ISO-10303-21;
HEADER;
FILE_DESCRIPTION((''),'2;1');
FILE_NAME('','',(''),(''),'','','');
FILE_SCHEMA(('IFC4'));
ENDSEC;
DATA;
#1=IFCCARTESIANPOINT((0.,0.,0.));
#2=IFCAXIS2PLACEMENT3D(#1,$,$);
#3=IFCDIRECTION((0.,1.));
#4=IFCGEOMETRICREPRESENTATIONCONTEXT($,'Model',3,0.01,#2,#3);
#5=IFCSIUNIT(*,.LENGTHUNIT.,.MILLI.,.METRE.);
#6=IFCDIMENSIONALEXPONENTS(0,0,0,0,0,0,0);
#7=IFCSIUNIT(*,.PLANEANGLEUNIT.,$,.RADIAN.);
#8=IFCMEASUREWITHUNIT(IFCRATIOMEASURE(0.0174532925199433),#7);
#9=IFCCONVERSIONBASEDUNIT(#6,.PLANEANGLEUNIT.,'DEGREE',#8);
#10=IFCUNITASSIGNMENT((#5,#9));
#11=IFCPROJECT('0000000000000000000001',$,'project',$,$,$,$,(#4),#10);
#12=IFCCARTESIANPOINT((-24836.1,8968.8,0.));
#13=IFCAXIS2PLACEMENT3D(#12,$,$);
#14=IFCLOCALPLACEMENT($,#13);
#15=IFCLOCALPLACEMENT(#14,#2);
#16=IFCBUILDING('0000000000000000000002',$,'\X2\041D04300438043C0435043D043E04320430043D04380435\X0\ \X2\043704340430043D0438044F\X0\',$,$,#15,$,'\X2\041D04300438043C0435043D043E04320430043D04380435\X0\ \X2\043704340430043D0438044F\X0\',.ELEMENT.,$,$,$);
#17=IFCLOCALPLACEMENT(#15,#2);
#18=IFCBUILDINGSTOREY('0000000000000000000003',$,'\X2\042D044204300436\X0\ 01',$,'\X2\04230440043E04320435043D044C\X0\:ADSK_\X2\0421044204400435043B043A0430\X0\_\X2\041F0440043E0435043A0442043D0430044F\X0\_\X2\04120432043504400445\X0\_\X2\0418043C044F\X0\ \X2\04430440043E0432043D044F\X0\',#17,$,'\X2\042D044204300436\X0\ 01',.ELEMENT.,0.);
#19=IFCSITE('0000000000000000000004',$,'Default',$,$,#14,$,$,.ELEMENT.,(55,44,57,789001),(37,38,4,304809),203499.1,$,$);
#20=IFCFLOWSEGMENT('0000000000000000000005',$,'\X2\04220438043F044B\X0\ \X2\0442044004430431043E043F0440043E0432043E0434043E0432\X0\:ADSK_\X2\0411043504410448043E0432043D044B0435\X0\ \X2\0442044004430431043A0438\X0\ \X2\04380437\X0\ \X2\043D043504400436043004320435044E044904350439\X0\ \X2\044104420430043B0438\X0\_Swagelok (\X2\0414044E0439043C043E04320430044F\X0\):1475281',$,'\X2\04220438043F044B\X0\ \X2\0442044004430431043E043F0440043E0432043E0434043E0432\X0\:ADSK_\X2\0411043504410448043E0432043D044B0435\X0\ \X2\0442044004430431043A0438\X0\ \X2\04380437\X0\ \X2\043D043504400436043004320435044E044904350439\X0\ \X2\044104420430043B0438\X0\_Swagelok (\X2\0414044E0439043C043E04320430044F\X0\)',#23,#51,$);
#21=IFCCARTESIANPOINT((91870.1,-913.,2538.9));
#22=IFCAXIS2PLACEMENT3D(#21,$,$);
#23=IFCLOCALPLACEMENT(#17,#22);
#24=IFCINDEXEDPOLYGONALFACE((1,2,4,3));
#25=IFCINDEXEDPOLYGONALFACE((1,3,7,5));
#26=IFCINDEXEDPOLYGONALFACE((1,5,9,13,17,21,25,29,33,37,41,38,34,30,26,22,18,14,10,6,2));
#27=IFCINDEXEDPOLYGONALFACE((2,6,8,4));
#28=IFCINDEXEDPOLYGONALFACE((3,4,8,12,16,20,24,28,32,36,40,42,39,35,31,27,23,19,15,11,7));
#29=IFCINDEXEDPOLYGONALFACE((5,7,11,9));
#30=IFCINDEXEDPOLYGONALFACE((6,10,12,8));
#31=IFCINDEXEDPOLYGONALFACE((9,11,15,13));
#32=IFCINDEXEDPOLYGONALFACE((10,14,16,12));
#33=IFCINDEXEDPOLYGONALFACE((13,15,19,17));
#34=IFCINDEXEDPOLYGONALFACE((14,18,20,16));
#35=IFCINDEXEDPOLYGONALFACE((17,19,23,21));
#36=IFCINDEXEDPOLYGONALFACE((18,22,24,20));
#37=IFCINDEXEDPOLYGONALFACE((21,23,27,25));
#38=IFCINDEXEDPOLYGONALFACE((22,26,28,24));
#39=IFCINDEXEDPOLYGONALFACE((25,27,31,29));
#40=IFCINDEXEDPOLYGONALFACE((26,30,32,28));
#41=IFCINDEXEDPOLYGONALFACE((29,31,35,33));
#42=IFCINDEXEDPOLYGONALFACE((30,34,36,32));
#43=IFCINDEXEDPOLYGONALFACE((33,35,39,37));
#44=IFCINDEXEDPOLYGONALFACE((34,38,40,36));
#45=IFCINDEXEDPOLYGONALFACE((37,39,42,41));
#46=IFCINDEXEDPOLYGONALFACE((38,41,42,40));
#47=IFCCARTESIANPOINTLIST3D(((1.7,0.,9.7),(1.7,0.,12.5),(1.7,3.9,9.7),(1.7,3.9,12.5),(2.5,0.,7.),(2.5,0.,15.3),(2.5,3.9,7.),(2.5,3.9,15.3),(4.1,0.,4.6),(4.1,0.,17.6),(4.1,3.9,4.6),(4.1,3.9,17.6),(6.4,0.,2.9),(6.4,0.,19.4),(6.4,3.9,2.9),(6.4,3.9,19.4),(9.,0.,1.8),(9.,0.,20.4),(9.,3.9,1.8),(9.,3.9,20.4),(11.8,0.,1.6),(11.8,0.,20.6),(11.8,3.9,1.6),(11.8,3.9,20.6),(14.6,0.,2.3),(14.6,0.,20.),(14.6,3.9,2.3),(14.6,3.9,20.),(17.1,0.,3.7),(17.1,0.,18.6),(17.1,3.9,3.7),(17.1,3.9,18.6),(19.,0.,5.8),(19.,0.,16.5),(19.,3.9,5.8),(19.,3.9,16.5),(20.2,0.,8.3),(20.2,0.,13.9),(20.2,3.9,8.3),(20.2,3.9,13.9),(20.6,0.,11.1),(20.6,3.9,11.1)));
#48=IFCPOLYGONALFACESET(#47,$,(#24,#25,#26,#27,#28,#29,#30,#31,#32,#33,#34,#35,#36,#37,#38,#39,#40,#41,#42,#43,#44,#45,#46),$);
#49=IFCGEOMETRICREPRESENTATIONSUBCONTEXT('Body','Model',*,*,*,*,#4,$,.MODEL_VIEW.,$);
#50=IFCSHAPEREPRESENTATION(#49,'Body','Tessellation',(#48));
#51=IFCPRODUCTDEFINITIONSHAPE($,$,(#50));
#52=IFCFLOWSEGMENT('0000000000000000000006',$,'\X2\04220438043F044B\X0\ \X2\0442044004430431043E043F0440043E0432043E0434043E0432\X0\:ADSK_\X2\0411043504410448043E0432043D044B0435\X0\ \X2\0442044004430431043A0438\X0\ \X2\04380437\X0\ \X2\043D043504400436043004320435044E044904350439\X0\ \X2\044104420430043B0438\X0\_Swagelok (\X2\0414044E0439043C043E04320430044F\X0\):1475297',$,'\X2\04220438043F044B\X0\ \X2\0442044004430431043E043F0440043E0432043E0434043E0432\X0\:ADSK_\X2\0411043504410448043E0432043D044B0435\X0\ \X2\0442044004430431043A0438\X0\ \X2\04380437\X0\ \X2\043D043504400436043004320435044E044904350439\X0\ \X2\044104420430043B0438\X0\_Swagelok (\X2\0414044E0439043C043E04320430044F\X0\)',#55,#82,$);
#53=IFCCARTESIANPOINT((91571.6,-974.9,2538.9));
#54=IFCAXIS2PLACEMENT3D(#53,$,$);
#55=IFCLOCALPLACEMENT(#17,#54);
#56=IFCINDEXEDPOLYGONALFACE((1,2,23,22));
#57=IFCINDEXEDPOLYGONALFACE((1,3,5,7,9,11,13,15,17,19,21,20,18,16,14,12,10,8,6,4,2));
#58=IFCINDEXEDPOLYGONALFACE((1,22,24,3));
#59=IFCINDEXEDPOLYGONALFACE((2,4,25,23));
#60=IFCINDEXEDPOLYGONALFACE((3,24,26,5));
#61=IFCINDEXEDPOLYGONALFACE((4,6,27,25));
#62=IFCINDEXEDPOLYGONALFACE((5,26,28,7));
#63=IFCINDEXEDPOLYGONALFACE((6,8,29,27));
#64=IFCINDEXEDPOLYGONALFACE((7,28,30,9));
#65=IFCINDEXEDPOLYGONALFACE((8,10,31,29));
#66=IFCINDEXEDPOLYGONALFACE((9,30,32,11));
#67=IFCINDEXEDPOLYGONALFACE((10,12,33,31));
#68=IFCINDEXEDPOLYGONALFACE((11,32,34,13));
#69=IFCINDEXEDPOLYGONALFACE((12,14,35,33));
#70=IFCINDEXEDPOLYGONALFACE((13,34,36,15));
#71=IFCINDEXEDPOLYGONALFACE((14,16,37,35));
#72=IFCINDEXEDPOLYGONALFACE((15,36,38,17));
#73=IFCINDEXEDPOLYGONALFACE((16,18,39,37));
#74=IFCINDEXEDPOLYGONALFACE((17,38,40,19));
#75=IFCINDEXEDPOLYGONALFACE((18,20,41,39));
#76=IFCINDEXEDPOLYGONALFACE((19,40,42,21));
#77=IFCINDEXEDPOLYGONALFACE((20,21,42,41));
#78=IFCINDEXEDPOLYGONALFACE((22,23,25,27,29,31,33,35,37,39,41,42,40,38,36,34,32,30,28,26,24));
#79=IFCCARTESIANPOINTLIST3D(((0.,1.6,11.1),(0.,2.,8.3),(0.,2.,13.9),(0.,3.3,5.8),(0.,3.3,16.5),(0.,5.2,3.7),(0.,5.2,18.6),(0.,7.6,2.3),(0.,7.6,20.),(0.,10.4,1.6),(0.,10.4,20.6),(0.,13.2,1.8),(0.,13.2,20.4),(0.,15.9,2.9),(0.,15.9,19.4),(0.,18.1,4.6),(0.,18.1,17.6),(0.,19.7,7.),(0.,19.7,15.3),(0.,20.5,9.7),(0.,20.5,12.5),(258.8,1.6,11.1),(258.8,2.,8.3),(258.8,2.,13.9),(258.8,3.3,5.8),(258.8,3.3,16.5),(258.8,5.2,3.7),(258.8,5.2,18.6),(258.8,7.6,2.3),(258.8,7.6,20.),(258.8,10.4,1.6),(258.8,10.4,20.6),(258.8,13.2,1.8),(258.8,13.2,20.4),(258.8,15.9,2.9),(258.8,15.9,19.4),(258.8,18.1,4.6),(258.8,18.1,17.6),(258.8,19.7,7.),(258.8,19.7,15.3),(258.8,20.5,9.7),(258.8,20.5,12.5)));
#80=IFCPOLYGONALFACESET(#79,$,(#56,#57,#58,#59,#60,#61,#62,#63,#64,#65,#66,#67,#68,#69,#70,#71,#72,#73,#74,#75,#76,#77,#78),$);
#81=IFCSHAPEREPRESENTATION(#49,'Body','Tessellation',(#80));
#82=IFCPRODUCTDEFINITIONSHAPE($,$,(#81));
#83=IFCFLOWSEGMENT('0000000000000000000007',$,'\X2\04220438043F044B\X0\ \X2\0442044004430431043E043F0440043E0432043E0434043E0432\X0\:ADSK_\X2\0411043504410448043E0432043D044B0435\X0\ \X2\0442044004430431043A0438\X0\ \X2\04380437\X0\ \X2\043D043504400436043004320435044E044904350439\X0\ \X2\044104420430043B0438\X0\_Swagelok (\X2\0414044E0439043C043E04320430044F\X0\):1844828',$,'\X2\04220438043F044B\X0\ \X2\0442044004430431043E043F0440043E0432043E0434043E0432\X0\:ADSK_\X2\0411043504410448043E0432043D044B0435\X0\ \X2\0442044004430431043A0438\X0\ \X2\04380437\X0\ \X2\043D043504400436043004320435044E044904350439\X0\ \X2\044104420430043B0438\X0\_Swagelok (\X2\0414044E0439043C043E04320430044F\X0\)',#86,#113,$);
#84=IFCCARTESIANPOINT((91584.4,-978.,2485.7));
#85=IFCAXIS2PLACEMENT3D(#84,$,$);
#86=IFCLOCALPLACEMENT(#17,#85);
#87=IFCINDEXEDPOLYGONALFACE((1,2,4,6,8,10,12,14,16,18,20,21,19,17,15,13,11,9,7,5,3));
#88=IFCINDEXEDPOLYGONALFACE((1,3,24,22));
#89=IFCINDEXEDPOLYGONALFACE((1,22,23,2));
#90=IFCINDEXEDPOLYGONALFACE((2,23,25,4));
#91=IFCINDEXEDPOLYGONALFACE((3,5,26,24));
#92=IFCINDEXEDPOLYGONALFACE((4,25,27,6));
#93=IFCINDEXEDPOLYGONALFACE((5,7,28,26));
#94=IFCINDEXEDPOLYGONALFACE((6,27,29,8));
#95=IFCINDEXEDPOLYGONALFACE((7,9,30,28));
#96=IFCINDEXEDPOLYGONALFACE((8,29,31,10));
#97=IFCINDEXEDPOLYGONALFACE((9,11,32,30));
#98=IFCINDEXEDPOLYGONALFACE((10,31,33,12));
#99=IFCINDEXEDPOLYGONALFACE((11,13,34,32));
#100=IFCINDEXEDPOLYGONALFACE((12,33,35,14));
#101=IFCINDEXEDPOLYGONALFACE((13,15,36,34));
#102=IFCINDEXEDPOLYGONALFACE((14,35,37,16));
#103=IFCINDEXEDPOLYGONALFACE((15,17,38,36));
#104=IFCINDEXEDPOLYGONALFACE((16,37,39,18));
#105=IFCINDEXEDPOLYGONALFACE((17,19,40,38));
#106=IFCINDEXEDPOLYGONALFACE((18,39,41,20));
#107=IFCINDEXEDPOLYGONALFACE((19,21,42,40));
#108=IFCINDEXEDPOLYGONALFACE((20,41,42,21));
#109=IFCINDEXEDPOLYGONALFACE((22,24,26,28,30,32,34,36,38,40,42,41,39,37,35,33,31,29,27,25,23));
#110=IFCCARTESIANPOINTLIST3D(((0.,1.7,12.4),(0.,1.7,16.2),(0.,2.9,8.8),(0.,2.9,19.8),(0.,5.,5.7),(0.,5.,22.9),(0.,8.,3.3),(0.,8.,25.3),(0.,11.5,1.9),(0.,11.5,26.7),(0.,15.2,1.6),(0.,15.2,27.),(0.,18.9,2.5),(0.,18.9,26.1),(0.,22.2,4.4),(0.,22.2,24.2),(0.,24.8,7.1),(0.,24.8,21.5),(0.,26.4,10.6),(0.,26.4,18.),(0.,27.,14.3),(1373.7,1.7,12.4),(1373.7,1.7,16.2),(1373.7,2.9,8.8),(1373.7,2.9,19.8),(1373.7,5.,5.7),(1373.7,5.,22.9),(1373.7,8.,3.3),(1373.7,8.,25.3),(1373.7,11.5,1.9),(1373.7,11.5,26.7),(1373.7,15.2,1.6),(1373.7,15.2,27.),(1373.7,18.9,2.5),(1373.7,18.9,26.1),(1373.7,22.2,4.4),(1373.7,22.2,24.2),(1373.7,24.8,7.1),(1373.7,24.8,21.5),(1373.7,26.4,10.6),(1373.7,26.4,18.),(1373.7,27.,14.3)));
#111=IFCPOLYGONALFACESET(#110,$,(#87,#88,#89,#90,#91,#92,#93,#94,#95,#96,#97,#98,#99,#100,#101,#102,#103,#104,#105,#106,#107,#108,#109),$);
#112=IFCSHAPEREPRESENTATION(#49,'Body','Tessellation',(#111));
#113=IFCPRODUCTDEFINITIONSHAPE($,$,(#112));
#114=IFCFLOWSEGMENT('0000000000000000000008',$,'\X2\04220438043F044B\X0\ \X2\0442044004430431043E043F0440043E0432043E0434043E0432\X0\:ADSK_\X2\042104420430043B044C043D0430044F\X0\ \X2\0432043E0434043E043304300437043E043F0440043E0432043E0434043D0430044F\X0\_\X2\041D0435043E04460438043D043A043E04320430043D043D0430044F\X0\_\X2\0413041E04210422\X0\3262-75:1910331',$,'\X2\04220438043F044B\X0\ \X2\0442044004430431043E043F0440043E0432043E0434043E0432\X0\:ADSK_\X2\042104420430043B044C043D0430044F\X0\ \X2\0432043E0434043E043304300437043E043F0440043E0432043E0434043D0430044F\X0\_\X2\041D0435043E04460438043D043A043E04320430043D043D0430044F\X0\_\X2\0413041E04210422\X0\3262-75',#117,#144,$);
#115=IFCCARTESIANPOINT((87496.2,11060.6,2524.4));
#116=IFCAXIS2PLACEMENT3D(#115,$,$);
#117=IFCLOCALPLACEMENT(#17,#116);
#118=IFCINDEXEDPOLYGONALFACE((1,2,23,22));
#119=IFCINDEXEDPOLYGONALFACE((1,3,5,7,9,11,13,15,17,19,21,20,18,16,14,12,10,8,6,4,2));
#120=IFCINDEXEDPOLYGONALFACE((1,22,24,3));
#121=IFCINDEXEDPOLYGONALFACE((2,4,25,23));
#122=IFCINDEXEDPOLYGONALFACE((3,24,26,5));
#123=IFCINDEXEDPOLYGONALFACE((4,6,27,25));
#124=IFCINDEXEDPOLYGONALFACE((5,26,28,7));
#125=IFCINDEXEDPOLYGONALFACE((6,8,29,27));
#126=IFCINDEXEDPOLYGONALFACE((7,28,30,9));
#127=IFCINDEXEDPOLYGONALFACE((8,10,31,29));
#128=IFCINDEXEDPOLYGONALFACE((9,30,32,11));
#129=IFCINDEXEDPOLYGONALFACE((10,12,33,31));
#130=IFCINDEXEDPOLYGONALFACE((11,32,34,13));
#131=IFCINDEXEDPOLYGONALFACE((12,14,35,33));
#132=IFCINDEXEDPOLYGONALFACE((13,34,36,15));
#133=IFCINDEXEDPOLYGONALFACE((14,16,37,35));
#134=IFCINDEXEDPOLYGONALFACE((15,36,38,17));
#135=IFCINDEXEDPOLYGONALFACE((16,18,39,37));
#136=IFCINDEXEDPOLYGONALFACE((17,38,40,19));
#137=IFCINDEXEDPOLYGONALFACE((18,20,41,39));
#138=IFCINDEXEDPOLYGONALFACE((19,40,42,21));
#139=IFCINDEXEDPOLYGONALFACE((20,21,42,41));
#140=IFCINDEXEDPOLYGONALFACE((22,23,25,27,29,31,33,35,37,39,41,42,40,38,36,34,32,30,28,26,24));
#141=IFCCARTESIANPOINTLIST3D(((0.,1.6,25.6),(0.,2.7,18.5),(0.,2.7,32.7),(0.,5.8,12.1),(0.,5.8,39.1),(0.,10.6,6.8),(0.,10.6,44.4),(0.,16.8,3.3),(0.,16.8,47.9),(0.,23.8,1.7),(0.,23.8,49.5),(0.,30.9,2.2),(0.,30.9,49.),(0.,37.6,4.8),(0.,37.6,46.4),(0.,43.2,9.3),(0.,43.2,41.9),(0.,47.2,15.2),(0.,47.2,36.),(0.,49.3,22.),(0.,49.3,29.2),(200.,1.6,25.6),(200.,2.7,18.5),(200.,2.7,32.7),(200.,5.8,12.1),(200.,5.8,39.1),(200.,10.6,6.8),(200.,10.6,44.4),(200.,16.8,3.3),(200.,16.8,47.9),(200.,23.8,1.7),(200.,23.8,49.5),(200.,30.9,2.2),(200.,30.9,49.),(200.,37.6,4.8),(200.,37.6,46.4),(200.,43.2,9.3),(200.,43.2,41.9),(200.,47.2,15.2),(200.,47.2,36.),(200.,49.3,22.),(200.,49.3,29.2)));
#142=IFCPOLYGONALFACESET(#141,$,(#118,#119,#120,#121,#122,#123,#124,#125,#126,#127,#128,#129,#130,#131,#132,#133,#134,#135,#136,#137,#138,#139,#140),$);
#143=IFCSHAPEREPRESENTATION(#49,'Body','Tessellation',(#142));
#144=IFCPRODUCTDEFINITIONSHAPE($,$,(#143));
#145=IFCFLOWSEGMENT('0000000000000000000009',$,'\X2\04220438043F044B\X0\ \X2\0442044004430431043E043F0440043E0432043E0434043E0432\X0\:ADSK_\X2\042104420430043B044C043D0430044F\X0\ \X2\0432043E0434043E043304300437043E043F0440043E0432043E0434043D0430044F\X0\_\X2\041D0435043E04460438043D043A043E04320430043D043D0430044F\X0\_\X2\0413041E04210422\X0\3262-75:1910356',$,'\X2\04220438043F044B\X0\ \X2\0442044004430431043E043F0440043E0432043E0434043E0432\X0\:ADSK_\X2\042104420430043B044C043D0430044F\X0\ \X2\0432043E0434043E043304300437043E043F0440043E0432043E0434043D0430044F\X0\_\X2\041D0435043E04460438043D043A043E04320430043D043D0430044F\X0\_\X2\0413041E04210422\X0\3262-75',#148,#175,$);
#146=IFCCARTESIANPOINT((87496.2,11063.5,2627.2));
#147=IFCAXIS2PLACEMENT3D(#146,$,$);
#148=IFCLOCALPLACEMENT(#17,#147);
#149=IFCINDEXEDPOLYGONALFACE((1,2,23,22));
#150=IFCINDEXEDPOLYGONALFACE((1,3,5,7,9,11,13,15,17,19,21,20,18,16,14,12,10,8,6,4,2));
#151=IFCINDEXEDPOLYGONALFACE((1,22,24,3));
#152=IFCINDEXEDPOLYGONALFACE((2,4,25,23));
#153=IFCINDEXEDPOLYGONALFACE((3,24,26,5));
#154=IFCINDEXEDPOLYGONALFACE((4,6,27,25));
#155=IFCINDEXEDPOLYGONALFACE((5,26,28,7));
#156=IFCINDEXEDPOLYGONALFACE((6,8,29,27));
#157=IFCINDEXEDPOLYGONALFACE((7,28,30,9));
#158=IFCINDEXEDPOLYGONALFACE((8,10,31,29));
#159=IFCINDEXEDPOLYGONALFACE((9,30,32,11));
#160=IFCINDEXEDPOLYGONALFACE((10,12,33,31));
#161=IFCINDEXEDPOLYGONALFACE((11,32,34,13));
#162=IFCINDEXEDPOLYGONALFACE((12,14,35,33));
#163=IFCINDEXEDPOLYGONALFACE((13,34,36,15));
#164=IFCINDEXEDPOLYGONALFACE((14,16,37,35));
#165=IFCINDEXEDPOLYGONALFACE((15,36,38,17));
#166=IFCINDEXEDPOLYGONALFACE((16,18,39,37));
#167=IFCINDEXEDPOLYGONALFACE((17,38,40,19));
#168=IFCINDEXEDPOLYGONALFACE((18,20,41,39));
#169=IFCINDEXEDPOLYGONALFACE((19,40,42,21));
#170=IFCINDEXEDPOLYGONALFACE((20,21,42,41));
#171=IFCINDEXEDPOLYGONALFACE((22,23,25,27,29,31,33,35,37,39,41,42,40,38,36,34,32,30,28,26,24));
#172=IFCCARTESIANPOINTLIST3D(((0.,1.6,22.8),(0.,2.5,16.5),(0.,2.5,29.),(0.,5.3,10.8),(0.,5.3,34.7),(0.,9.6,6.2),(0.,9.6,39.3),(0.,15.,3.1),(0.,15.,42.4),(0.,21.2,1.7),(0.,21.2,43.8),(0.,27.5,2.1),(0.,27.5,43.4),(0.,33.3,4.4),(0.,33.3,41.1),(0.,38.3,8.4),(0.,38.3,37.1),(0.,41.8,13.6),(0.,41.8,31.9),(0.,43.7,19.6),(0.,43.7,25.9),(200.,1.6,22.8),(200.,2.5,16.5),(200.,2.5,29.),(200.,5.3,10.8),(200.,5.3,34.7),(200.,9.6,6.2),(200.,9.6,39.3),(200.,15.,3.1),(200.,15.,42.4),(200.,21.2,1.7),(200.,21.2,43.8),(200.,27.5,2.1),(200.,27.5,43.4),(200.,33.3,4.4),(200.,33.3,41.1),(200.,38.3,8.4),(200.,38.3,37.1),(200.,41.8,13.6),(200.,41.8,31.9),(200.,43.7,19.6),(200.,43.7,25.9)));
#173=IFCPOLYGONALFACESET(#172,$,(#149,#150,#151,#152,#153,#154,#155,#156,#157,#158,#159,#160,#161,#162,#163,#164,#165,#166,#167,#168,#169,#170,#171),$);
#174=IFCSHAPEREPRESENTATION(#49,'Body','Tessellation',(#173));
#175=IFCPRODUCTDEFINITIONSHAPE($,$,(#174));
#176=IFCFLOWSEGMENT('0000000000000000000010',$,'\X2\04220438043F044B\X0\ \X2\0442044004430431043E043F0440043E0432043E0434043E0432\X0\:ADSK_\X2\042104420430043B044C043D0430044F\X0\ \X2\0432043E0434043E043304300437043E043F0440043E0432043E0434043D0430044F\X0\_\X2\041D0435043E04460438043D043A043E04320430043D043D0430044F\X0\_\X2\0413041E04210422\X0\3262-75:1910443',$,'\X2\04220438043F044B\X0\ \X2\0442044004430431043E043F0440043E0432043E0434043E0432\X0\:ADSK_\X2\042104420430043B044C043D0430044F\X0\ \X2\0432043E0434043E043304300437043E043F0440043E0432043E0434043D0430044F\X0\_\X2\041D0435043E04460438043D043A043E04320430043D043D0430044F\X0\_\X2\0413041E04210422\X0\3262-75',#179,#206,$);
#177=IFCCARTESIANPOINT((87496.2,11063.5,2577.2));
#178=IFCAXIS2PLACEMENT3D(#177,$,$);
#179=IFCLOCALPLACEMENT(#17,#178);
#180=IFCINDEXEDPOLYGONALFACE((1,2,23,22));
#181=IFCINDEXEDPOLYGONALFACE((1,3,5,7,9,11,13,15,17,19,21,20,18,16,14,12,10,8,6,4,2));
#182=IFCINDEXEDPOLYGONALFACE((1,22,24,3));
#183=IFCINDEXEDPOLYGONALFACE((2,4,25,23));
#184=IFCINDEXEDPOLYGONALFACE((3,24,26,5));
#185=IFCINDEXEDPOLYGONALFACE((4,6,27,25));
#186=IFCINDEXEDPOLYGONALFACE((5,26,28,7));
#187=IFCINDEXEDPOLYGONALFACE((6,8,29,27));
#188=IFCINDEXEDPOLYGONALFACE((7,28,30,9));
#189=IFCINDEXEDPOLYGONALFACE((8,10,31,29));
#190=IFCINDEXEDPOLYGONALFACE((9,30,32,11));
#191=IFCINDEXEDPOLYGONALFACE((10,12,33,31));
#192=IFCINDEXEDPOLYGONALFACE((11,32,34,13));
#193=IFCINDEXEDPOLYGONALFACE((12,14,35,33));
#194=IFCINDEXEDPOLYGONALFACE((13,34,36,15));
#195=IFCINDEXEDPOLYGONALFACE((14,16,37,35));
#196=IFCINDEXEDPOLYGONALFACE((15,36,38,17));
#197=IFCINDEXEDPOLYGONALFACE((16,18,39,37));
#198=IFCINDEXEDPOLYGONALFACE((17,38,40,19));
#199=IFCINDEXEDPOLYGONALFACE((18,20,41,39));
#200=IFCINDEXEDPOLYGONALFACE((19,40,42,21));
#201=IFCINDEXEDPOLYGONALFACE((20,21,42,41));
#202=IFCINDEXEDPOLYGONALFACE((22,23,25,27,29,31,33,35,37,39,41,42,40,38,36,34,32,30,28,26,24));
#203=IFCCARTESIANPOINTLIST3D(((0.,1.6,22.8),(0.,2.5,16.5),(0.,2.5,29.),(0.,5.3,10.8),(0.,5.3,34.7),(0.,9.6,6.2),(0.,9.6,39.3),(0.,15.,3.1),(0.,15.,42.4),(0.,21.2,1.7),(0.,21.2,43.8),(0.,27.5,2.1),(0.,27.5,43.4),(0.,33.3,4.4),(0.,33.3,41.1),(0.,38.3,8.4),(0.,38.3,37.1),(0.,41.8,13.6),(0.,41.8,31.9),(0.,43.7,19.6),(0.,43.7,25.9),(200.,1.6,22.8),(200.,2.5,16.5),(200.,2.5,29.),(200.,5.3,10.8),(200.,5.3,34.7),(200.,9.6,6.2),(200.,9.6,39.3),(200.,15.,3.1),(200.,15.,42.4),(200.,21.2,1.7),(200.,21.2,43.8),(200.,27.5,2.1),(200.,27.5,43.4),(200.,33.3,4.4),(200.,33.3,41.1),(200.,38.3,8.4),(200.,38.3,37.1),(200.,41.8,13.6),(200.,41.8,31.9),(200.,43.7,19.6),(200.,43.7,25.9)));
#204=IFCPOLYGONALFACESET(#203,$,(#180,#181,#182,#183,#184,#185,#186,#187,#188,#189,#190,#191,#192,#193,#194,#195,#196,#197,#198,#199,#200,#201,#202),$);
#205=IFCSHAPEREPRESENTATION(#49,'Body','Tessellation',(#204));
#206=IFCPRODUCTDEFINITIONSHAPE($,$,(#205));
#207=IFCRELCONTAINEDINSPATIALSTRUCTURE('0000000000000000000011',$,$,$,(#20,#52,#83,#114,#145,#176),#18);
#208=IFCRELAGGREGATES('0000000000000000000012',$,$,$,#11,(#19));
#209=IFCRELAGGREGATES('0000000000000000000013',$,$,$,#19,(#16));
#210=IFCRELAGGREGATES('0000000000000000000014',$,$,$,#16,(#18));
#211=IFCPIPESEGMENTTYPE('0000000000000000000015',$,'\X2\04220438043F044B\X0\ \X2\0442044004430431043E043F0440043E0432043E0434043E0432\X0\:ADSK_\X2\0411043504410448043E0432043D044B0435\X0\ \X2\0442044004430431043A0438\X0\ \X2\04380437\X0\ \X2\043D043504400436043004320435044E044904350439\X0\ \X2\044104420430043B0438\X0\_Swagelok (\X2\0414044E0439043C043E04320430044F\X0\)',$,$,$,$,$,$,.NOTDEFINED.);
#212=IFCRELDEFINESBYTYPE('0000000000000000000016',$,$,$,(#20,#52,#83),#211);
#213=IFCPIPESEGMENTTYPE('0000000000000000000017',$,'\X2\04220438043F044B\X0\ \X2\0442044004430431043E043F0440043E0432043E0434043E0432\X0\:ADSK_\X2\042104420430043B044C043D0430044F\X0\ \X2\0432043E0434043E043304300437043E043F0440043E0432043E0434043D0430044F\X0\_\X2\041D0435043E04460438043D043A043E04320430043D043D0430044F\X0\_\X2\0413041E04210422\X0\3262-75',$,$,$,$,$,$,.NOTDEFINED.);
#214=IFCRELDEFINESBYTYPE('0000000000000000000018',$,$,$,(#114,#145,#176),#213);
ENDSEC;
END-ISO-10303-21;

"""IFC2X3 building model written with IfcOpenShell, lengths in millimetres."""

from ifc_helpers import new_model, entity, si_unit, converted_unit, direction, frame, origin, origin_2d_with_axis, place, context, subcontext, project, spatial, circle, extrude, type_object, element, save


model = new_model("IFC2X3")

# Units and contexts
model_context = context("Model", 3, precision=0.01, world=origin(), true_north=direction((0.0, 1.0)))
body_context = subcontext(model_context, "Body", "Model", "MODEL_VIEW")
ifc_project = project(units=[si_unit("LENGTHUNIT", "METRE", prefix="MILLI"), converted_unit("PLANEANGLEUNIT", "DEGREE", entity("IfcRatioMeasure", 0.0174532925199433), si_unit("PLANEANGLEUNIT", "RADIAN"), dimensions=[0, 0, 0, 0, 0, 0, 0])], contexts=[model_context])

# Site, building, storey
site_placement = place(None, frame((-24836.1, 8968.8, 0.0)))
site = spatial("IfcSite", under=ifc_project, at=site_placement, Name="Default", CompositionType="ELEMENT", RefLatitude=(55, 44, 57, 789001), RefLongitude=(37, 38, 4, 304809), RefElevation=203499.1)
building_placement = place(site_placement, origin())
building = spatial("IfcBuilding", under=site, at=building_placement, Name="Наименование здания", LongName="Наименование здания", CompositionType="ELEMENT")
storey_placement = place(building_placement, origin())
storey = spatial("IfcBuildingStorey", under=building, at=storey_placement, Name="Этаж 01", ObjectType="Уровень:ADSK_Стрелка_Проектная_Вверх_Имя уровня", LongName="Этаж 01", CompositionType="ELEMENT", Elevation=0.0)

# Flow segments
pipe_segment_type_1 = type_object("IfcPipeSegmentType", Name="Типы трубопроводов:ADSK_Бесшовные трубки из нержавеющей стали_Swagelok (Дюймовая)", PredefinedType="NOTDEFINED")
flow_segment_1_placement = place(storey_placement, frame((91870.1, -913.0, 2538.9)))
element("IfcFlowSegment", 1, at=flow_segment_1_placement, inside=storey, type_object=pipe_segment_type_1, Name="Типы трубопроводов:ADSK_Бесшовные трубки из нержавеющей стали_Swagelok (Дюймовая):1475281", ObjectType="Типы трубопроводов:ADSK_Бесшовные трубки из нержавеющей стали_Swagelok (Дюймовая)", context=body_context, shape_type="SweptSolid", body=[
    extrude(circle(Radius=9.5, at=origin_2d_with_axis()), frame((11.1, 0.0, 11.1), z_axis=(0.0, 1.0, 0.0), x_axis=(1.0, 0.0, 0.0)), (0.0, 0.0, 1.0), 3.9),
])
flow_segment_2_placement = place(storey_placement, frame((91571.6, -974.9, 2538.9)))
element("IfcFlowSegment", 2, at=flow_segment_2_placement, inside=storey, type_object=pipe_segment_type_1, Name="Типы трубопроводов:ADSK_Бесшовные трубки из нержавеющей стали_Swagelok (Дюймовая):1475297", ObjectType="Типы трубопроводов:ADSK_Бесшовные трубки из нержавеющей стали_Swagelok (Дюймовая)", context=body_context, shape_type="SweptSolid", body=[
    extrude(circle(Radius=9.5, at=origin_2d_with_axis()), frame((0.0, 11.1, 11.1), z_axis=(1.0, 0.0, 0.0), x_axis=(0.0, -1.0, 0.0)), (0.0, 0.0, 1.0), 258.8),
])
flow_segment_3_placement = place(storey_placement, frame((91584.4, -978.0, 2485.7)))
element("IfcFlowSegment", 3, at=flow_segment_3_placement, inside=storey, type_object=pipe_segment_type_1, Name="Типы трубопроводов:ADSK_Бесшовные трубки из нержавеющей стали_Swagelok (Дюймовая):1844828", ObjectType="Типы трубопроводов:ADSK_Бесшовные трубки из нержавеющей стали_Swagelok (Дюймовая)", context=body_context, shape_type="SweptSolid", body=[
    extrude(circle(Radius=12.7, at=origin_2d_with_axis()), frame((0.0, 14.3, 14.3), z_axis=(1.0, 0.0, 0.0), x_axis=(0.0, 1.0, 0.0)), (0.0, 0.0, 1.0), 1373.7),
])
pipe_segment_type_2 = type_object("IfcPipeSegmentType", Name="Типы трубопроводов:ADSK_Стальная водогазопроводная_Неоцинкованная_ГОСТ3262-75", PredefinedType="NOTDEFINED")
flow_segment_4_placement = place(storey_placement, frame((87496.2, 11060.6, 2524.4)))
element("IfcFlowSegment", 4, at=flow_segment_4_placement, inside=storey, type_object=pipe_segment_type_2, Name="Типы трубопроводов:ADSK_Стальная водогазопроводная_Неоцинкованная_ГОСТ3262-75:1910331", ObjectType="Типы трубопроводов:ADSK_Стальная водогазопроводная_Неоцинкованная_ГОСТ3262-75", context=body_context, shape_type="SweptSolid", body=[
    extrude(circle(Radius=24.0, at=origin_2d_with_axis()), frame((0.0, 25.6, 25.6), z_axis=(1.0, 0.0, 0.0), x_axis=(0.0, -1.0, 0.0)), (0.0, 0.0, 1.0), 200.0),
])
for number, where, name in (
    (5, (87496.2, 11063.5, 2627.2), "Типы трубопроводов:ADSK_Стальная водогазопроводная_Неоцинкованная_ГОСТ3262-75:1910356"),
    (6, (87496.2, 11063.5, 2577.2), "Типы трубопроводов:ADSK_Стальная водогазопроводная_Неоцинкованная_ГОСТ3262-75:1910443"),
):
    element("IfcFlowSegment", number, at=place(storey_placement, frame(where)), inside=storey, type_object=pipe_segment_type_2, Name=name, ObjectType="Типы трубопроводов:ADSK_Стальная водогазопроводная_Неоцинкованная_ГОСТ3262-75", context=body_context, shape_type="SweptSolid", body=[
        extrude(circle(Radius=21.1, at=origin_2d_with_axis()), frame((0.0, 22.8, 22.8), z_axis=(1.0, 0.0, 0.0), x_axis=(0.0, -1.0, 0.0)), (0.0, 0.0, 1.0), 200.0),
    ])

save(model, "model.ifc")
